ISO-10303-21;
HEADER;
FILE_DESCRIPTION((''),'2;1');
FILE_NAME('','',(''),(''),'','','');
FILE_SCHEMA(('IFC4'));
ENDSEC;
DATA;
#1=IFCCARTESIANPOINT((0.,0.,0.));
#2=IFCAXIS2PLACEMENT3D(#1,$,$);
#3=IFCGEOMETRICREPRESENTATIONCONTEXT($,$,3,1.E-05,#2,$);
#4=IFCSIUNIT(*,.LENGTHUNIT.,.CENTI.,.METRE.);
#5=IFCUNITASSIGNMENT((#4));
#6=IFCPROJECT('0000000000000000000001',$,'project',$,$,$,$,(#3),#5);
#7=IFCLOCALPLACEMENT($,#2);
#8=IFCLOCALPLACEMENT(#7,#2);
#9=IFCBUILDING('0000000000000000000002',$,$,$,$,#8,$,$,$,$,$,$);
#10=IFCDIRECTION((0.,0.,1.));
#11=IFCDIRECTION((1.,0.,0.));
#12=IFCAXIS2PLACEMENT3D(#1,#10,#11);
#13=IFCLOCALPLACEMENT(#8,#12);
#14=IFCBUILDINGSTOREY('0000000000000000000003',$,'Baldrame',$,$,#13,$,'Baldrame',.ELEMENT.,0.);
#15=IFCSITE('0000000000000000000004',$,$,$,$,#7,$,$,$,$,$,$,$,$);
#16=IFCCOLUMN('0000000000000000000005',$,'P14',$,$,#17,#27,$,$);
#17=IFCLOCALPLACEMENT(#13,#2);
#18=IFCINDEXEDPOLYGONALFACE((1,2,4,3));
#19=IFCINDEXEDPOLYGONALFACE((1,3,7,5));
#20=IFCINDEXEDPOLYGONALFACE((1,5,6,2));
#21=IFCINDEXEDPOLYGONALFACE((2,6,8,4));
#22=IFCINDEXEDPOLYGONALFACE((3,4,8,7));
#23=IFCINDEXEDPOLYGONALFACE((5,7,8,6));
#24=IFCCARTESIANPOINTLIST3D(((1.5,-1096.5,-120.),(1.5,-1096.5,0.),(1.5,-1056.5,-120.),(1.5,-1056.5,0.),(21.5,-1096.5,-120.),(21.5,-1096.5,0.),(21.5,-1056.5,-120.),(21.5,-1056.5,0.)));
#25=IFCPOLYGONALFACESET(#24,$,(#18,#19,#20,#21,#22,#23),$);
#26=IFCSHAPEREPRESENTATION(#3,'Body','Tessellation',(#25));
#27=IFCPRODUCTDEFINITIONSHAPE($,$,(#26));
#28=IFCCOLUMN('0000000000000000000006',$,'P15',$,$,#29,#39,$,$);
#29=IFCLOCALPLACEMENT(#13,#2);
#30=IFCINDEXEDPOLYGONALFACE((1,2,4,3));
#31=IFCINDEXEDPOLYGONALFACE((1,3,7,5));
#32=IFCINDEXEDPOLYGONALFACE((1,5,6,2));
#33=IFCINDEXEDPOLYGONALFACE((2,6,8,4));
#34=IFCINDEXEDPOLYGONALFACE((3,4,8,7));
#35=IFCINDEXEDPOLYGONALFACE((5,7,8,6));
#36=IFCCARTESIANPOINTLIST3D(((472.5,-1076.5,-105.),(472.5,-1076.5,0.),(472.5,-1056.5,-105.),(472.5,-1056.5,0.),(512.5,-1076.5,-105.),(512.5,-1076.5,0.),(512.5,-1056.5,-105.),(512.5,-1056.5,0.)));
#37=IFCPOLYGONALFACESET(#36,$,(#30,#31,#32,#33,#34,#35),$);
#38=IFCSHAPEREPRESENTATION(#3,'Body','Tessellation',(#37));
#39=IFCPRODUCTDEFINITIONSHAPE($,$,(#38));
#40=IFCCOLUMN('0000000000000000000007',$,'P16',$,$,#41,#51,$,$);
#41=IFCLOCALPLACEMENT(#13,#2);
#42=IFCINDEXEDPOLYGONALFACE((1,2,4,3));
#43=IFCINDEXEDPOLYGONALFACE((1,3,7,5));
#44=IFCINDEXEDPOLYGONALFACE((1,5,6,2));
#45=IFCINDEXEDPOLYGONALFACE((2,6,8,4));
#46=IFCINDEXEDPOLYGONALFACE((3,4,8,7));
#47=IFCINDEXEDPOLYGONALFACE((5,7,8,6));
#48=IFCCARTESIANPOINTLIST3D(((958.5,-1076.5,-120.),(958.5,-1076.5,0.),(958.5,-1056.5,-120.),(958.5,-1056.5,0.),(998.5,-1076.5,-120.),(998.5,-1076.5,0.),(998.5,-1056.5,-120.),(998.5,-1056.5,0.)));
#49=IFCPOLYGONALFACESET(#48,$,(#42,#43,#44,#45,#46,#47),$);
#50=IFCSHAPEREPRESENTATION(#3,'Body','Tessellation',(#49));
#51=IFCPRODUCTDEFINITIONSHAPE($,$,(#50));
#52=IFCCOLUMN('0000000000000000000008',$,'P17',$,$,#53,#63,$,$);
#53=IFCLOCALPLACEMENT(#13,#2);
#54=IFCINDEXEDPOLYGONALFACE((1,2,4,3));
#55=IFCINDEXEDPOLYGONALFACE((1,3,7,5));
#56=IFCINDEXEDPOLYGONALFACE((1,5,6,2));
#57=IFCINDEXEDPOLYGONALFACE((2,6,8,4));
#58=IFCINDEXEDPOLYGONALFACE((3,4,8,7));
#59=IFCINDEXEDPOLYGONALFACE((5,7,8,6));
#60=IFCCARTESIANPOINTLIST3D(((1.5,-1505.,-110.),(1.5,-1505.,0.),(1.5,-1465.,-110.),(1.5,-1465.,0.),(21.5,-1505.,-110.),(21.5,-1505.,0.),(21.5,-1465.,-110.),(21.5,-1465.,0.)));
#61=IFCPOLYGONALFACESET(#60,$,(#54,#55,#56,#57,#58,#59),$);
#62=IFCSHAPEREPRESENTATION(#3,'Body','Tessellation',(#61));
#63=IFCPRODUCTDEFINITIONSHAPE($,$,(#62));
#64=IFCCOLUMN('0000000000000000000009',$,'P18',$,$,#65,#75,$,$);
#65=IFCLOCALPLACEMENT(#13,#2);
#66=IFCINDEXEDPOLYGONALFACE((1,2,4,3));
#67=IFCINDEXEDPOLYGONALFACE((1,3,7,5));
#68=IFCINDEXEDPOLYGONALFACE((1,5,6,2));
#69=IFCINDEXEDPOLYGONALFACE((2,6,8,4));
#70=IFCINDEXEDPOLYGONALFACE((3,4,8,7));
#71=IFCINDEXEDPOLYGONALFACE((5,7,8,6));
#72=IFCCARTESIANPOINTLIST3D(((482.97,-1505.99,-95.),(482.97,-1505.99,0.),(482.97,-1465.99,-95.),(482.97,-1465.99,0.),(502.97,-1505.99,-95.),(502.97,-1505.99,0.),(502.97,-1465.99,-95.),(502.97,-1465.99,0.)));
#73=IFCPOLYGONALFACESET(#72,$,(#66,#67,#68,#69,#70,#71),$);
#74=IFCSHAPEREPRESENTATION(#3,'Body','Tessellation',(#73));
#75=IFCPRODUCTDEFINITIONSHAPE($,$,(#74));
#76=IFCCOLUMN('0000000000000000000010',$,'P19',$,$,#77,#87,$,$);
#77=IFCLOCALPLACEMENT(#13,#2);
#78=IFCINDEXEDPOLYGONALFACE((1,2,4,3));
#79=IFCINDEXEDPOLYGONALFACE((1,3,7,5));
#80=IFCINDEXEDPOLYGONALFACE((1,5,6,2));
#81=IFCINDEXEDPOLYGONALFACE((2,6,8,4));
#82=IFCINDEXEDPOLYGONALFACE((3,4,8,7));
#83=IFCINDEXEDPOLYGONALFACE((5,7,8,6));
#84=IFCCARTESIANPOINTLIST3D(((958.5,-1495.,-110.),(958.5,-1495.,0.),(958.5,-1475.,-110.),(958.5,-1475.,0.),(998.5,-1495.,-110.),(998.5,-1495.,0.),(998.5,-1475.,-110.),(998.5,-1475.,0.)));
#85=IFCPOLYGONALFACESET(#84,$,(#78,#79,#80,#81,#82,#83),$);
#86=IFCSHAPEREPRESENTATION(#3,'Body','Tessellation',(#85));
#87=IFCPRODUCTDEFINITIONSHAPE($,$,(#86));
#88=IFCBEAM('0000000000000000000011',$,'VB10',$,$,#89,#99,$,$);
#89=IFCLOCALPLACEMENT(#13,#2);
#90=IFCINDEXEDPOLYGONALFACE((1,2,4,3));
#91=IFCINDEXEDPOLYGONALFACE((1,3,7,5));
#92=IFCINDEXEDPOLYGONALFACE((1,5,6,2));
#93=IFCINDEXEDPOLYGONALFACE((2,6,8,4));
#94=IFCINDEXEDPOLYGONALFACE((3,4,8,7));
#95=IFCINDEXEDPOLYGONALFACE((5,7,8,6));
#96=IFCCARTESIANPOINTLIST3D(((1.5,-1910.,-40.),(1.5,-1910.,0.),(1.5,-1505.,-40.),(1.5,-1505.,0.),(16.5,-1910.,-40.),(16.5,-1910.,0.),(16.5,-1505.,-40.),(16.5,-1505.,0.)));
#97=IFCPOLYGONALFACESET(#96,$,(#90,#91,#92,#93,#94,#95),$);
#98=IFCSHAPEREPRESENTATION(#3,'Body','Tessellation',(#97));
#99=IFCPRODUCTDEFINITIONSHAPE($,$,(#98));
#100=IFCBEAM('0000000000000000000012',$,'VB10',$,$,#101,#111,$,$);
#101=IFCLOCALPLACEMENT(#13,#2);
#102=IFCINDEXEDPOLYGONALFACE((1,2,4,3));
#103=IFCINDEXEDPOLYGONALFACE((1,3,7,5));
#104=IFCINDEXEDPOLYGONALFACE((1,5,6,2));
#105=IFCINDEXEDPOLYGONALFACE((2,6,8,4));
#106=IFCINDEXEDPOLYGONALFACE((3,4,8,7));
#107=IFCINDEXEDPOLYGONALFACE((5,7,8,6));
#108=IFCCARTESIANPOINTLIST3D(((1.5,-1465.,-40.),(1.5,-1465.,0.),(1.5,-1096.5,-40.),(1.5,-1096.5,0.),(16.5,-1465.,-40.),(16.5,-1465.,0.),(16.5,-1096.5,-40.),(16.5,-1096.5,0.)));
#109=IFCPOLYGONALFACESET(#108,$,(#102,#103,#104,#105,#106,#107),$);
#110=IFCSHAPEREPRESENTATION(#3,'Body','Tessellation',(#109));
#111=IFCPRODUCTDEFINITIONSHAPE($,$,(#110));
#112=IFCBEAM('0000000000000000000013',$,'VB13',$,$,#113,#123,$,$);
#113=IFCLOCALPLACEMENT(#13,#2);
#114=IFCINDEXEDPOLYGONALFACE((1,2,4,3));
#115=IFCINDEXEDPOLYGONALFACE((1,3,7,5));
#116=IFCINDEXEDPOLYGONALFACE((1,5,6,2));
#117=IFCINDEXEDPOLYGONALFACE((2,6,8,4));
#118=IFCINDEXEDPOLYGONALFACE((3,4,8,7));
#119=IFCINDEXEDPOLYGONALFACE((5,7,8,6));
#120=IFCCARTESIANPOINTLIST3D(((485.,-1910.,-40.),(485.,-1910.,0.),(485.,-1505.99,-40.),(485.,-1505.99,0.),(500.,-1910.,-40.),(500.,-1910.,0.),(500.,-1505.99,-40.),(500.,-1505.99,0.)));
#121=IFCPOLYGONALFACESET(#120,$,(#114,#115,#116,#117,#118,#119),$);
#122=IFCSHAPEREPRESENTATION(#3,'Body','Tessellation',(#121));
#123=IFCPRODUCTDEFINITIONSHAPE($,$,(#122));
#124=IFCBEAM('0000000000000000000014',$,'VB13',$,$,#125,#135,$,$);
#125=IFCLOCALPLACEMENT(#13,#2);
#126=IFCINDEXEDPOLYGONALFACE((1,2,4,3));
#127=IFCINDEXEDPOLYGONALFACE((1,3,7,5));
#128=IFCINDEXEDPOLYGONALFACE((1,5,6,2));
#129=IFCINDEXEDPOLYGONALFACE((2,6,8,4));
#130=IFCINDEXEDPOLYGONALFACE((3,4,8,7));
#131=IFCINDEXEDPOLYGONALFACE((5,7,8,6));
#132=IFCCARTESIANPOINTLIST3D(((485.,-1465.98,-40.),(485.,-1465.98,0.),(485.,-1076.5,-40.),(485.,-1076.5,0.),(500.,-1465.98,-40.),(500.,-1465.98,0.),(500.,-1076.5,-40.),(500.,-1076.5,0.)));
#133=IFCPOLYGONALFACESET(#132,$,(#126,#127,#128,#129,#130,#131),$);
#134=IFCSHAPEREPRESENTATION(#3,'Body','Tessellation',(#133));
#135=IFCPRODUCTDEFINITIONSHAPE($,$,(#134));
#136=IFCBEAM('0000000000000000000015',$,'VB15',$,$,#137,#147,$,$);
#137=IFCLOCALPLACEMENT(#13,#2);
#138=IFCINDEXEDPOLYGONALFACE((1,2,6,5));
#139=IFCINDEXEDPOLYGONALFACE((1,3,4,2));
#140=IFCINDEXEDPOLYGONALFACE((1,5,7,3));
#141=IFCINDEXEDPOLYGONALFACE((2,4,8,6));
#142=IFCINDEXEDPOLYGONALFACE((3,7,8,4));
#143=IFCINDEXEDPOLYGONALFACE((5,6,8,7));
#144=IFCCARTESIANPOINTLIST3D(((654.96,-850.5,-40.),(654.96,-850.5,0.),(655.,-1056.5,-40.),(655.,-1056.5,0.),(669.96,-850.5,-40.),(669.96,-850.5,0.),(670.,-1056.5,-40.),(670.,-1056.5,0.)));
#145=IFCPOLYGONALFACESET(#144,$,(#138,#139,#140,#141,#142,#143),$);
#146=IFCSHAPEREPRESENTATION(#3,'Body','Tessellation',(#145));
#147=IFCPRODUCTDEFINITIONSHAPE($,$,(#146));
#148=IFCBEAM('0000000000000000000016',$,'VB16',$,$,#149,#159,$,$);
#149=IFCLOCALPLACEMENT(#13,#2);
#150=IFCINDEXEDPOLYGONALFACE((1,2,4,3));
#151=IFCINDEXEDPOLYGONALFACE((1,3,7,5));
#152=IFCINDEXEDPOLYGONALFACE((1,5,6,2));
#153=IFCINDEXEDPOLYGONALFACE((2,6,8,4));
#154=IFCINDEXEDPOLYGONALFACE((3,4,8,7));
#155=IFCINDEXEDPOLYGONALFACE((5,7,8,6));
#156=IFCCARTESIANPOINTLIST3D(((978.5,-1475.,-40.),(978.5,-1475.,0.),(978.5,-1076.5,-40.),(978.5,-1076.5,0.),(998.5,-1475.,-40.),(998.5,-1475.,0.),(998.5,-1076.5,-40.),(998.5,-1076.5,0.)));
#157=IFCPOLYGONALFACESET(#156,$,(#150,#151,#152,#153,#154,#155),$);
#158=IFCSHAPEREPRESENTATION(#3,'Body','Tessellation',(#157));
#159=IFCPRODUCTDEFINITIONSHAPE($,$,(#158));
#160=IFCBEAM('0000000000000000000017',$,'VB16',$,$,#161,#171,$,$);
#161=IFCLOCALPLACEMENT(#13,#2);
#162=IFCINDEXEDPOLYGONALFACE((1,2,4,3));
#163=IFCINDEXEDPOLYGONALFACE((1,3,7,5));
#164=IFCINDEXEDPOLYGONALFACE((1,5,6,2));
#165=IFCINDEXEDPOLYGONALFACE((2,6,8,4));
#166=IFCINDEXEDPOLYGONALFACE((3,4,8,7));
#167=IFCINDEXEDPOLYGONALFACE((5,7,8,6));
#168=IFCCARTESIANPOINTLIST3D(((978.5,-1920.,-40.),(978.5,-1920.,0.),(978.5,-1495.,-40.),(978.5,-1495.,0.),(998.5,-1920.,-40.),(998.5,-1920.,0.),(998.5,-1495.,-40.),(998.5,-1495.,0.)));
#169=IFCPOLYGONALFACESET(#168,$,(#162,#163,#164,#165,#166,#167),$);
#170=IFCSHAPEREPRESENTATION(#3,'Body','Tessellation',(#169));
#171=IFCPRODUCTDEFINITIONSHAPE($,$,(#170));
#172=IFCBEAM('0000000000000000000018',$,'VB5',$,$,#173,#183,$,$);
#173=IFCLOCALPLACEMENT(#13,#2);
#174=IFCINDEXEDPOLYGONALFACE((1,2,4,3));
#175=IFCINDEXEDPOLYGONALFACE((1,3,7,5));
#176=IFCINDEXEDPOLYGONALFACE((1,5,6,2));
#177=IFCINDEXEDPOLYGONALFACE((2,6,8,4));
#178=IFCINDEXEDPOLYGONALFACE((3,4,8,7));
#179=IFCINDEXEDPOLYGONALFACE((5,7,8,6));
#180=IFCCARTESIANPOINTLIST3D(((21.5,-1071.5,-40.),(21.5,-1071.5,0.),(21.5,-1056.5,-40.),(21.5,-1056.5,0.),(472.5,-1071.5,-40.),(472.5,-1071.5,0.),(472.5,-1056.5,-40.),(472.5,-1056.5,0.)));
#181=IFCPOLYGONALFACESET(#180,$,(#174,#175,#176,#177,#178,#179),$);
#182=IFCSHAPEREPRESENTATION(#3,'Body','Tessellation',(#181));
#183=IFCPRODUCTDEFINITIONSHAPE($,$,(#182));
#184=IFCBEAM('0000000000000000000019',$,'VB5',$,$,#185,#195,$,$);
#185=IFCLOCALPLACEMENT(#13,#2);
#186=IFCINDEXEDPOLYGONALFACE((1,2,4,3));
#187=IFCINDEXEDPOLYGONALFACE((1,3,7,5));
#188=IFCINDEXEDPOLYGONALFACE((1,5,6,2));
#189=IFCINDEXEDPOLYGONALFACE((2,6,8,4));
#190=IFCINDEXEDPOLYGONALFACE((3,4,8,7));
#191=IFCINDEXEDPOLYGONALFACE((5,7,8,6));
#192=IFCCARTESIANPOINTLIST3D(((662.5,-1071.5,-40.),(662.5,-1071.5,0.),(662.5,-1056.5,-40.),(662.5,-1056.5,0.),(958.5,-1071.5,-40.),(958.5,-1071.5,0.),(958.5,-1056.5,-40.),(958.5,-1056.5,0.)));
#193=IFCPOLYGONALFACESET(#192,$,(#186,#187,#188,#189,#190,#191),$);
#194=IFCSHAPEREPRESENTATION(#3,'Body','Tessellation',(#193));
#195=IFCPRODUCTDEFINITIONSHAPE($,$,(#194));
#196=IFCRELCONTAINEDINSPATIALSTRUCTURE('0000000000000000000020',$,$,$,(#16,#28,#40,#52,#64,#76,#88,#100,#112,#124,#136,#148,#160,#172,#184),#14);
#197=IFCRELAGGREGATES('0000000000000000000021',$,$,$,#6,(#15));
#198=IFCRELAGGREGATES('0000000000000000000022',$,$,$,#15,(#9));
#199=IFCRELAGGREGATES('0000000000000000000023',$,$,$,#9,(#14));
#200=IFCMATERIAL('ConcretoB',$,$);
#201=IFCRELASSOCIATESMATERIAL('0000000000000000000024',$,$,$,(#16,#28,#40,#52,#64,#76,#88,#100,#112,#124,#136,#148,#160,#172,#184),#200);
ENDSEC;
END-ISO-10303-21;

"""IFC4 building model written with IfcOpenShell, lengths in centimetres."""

from ifc_helpers import new_model, si_unit, frame, origin, origin_with_axes, place, context, project, spatial, polyline, outline, extrude, material, element, save


model = new_model("IFC4")

# Units and contexts
context_of_model = context(None, 3, precision=1e-05, world=origin())
ifc_project = project(units=[si_unit("LENGTHUNIT", "METRE", prefix="CENTI")], contexts=[context_of_model])

# Site, building, storey
site_placement = place(None, origin())
site = spatial("IfcSite", under=ifc_project, at=site_placement)
building_placement = place(site_placement, origin())
building = spatial("IfcBuilding", under=site, at=building_placement)
storey_placement = place(building_placement, origin_with_axes())
storey = spatial("IfcBuildingStorey", under=building, at=storey_placement, Name="Baldrame", LongName="Baldrame", CompositionType="ELEMENT", Elevation=0.0)

# Columns
ifc_material = material(Name="ConcretoB")
column_1_placement = place(storey_placement, frame((11.5, -1076.5, 0.0), z_axis=(0.0, 0.0, 1.0), x_axis=(1.0, 0.0, 0.0)))
element("IfcColumn", 1, at=column_1_placement, inside=storey, material=ifc_material, Name="P14", context=context_of_model, shape_type="SolidModel", body=[
    extrude(outline(polyline([(10.0, 20.0), (-10.0, 20.0), (-10.0, -20.0), (10.0, -20.0), (10.0, 20.0)])), frame((0.0, 0.0, -120.0), z_axis=(0.0, 0.0, 1.0), x_axis=(1.0, 0.0, 0.0)), (0.0, 0.0, 1.0), 120.0),
])
column_2_placement = place(storey_placement, frame((492.5, -1066.5, 0.0), z_axis=(0.0, 0.0, 1.0), x_axis=(1.0, 0.0, 0.0)))
element("IfcColumn", 2, at=column_2_placement, inside=storey, material=ifc_material, Name="P15", context=context_of_model, shape_type="SolidModel", body=[
    extrude(outline(polyline([(-20.0, 10.0), (-20.0, -10.0), (20.0, -10.0), (20.0, 10.0), (-20.0, 10.0)])), frame((0.0, 0.0, -105.0), z_axis=(0.0, 0.0, 1.0), x_axis=(1.0, 0.0, 0.0)), (0.0, 0.0, 1.0), 105.0),
])
column_3_placement = place(storey_placement, frame((978.5, -1066.5, 0.0), z_axis=(0.0, 0.0, 1.0), x_axis=(1.0, 0.0, 0.0)))
element("IfcColumn", 3, at=column_3_placement, inside=storey, material=ifc_material, Name="P16", context=context_of_model, shape_type="SolidModel", body=[
    extrude(outline(polyline([(-20.0, 10.0), (-20.0, -10.0), (20.0, -10.0), (20.0, 10.0), (-20.0, 10.0)])), frame((0.0, 0.0, -120.0), z_axis=(0.0, 0.0, 1.0), x_axis=(1.0, 0.0, 0.0)), (0.0, 0.0, 1.0), 120.0),
])
column_4_placement = place(storey_placement, frame((11.5, -1485.0, 0.0), z_axis=(0.0, 0.0, 1.0), x_axis=(1.0, 0.0, 0.0)))
element("IfcColumn", 4, at=column_4_placement, inside=storey, material=ifc_material, Name="P17", context=context_of_model, shape_type="SolidModel", body=[
    extrude(outline(polyline([(-10.0, -20.0), (10.0, -20.0), (10.0, 20.0), (-10.0, 20.0), (-10.0, -20.0)])), frame((0.0, 0.0, -110.0), z_axis=(0.0, 0.0, 1.0), x_axis=(1.0, 0.0, 0.0)), (0.0, 0.0, 1.0), 110.0),
])
column_5_placement = place(storey_placement, frame((492.97, -1485.99, 0.0), z_axis=(0.0, 0.0, 1.0), x_axis=(1.0, 0.0, 0.0)))
element("IfcColumn", 5, at=column_5_placement, inside=storey, material=ifc_material, Name="P18", context=context_of_model, shape_type="SolidModel", body=[
    extrude(outline(polyline([(-10.0, -20.0), (10.0, -20.0), (10.0, 20.0), (-10.0, 20.0), (-10.0, -20.0)])), frame((0.0, 0.0, -95.0), z_axis=(0.0, 0.0, 1.0), x_axis=(1.0, 0.0, 0.0)), (0.0, 0.0, 1.0), 95.0),
])
column_6_placement = place(storey_placement, frame((978.5, -1485.0, 0.0), z_axis=(0.0, 0.0, 1.0), x_axis=(1.0, 0.0, 0.0)))
element("IfcColumn", 6, at=column_6_placement, inside=storey, material=ifc_material, Name="P19", context=context_of_model, shape_type="SolidModel", body=[
    extrude(outline(polyline([(-20.0, 10.0), (-20.0, -10.0), (20.0, -10.0), (20.0, 10.0), (-20.0, 10.0)])), frame((0.0, 0.0, -110.0), z_axis=(0.0, 0.0, 1.0), x_axis=(1.0, 0.0, 0.0)), (0.0, 0.0, 1.0), 110.0),
])

# Beams
beam_1_placement = place(storey_placement, frame((9.0, -1707.5, 0.0), z_axis=(0.0, 0.0, 1.0), x_axis=(1.0, 0.0, 0.0)))
element("IfcBeam", 7, at=beam_1_placement, inside=storey, material=ifc_material, Name="VB10", context=context_of_model, shape_type="SolidModel", body=[
    extrude(outline(polyline([(-7.5, -20.0), (7.5, -20.0), (7.5, 20.0), (-7.5, 20.0), (-7.5, -20.0)])), frame((0.0, -202.5, -20.0), z_axis=(0.0, 1.0, 0.0), x_axis=(1.0, 0.0, 0.0)), (0.0, 0.0, 1.0), 405.0),
])
beam_2_placement = place(storey_placement, frame((9.0, -1280.75, 0.0), z_axis=(0.0, 0.0, 1.0), x_axis=(1.0, 0.0, 0.0)))
element("IfcBeam", 8, at=beam_2_placement, inside=storey, material=ifc_material, Name="VB10", context=context_of_model, shape_type="SolidModel", body=[
    extrude(outline(polyline([(-7.5, -20.0), (7.5, -20.0), (7.5, 20.0), (-7.5, 20.0), (-7.5, -20.0)])), frame((0.0, -184.25, -20.0), z_axis=(0.0, 1.0, 0.0), x_axis=(1.0, 0.0, 0.0)), (0.0, 0.0, 1.0), 368.5),
])
beam_3_placement = place(storey_placement, frame((492.5, -1707.99, 0.0), z_axis=(0.0, 0.0, 1.0), x_axis=(1.0, 0.0, 0.0)))
element("IfcBeam", 9, at=beam_3_placement, inside=storey, material=ifc_material, Name="VB13", context=context_of_model, shape_type="SolidModel", body=[
    extrude(outline(polyline([(-7.5, -20.0), (7.5, -20.0), (7.5, 20.0), (-7.5, 20.0), (-7.5, -20.0)])), frame((0.0, -202.0, -20.0), z_axis=(0.0, 1.0, 0.0), x_axis=(1.0, 0.0, 0.0)), (0.0, 0.0, 1.0), 404.01),
])
beam_4_placement = place(storey_placement, frame((492.5, -1271.24, 0.0), z_axis=(0.0, 0.0, 1.0), x_axis=(1.0, 0.0, 0.0)))
element("IfcBeam", 10, at=beam_4_placement, inside=storey, material=ifc_material, Name="VB13", context=context_of_model, shape_type="SolidModel", body=[
    extrude(outline(polyline([(-7.5, -20.0), (7.5, -20.0), (7.5, 20.0), (-7.5, 20.0), (-7.5, -20.0)])), frame((0.0, -194.75, -20.0), z_axis=(0.0, 1.0, 0.0), x_axis=(1.0, 0.0, 0.0)), (0.0, 0.0, 1.0), 389.49),
])
beam_5_placement = place(storey_placement, frame((662.48, -953.5, 0.0), z_axis=(0.0, 0.0, 1.0), x_axis=(1.0, 0.0, 0.0)))
element("IfcBeam", 11, at=beam_5_placement, inside=storey, material=ifc_material, Name="VB15", context=context_of_model, shape_type="SolidModel", body=[
    extrude(outline(polyline([(-7.5, -20.0), (7.5, -20.0), (7.5, 20.0), (-7.5, 20.0), (-7.5, -20.0)])), frame((0.02, -103.0, -20.0), z_axis=(-0.000187, 1.0, 0.0), x_axis=(1.0, 0.000187, 0.0)), (0.0, 0.0, 1.0), 206.0),
])
beam_6_placement = place(storey_placement, frame((988.5, -1275.75, 0.0), z_axis=(0.0, 0.0, 1.0), x_axis=(1.0, 0.0, 0.0)))
element("IfcBeam", 12, at=beam_6_placement, inside=storey, material=ifc_material, Name="VB16", context=context_of_model, shape_type="SolidModel", body=[
    extrude(outline(polyline([(-10.0, -20.0), (10.0, -20.0), (10.0, 20.0), (-10.0, 20.0), (-10.0, -20.0)])), frame((0.0, -199.25, -20.0), z_axis=(0.0, 1.0, 0.0), x_axis=(1.0, 0.0, 0.0)), (0.0, 0.0, 1.0), 398.5),
])
beam_7_placement = place(storey_placement, frame((988.5, -1707.5, 0.0), z_axis=(0.0, 0.0, 1.0), x_axis=(1.0, 0.0, 0.0)))
element("IfcBeam", 13, at=beam_7_placement, inside=storey, material=ifc_material, Name="VB16", context=context_of_model, shape_type="SolidModel", body=[
    extrude(outline(polyline([(-10.0, -20.0), (10.0, -20.0), (10.0, 20.0), (-10.0, 20.0), (-10.0, -20.0)])), frame((0.0, -212.5, -20.0), z_axis=(0.0, 1.0, 0.0), x_axis=(1.0, 0.0, 0.0)), (0.0, 0.0, 1.0), 425.0),
])
beam_8_placement = place(storey_placement, frame((247.0, -1064.0, 0.0), z_axis=(0.0, 0.0, 1.0), x_axis=(1.0, 0.0, 0.0)))
element("IfcBeam", 14, at=beam_8_placement, inside=storey, material=ifc_material, Name="VB5", context=context_of_model, shape_type="SolidModel", body=[
    extrude(outline(polyline([(-7.5, -20.0), (7.5, -20.0), (7.5, 20.0), (-7.5, 20.0), (-7.5, -20.0)])), frame((-225.5, 0.0, -20.0), z_axis=(1.0, 0.0, 0.0), x_axis=(0.0, -1.0, 0.0)), (0.0, 0.0, 1.0), 451.0),
])
beam_9_placement = place(storey_placement, frame((810.5, -1064.0, 0.0), z_axis=(0.0, 0.0, 1.0), x_axis=(1.0, 0.0, 0.0)))
element("IfcBeam", 15, at=beam_9_placement, inside=storey, material=ifc_material, Name="VB5", context=context_of_model, shape_type="SolidModel", body=[
    extrude(outline(polyline([(-7.5, -20.0), (7.5, -20.0), (7.5, 20.0), (-7.5, 20.0), (-7.5, -20.0)])), frame((-148.0, 0.0, -20.0), z_axis=(1.0, 0.0, 0.0), x_axis=(0.0, -1.0, 0.0)), (0.0, 0.0, 1.0), 296.0),
])

save(model, "model.ifc")
